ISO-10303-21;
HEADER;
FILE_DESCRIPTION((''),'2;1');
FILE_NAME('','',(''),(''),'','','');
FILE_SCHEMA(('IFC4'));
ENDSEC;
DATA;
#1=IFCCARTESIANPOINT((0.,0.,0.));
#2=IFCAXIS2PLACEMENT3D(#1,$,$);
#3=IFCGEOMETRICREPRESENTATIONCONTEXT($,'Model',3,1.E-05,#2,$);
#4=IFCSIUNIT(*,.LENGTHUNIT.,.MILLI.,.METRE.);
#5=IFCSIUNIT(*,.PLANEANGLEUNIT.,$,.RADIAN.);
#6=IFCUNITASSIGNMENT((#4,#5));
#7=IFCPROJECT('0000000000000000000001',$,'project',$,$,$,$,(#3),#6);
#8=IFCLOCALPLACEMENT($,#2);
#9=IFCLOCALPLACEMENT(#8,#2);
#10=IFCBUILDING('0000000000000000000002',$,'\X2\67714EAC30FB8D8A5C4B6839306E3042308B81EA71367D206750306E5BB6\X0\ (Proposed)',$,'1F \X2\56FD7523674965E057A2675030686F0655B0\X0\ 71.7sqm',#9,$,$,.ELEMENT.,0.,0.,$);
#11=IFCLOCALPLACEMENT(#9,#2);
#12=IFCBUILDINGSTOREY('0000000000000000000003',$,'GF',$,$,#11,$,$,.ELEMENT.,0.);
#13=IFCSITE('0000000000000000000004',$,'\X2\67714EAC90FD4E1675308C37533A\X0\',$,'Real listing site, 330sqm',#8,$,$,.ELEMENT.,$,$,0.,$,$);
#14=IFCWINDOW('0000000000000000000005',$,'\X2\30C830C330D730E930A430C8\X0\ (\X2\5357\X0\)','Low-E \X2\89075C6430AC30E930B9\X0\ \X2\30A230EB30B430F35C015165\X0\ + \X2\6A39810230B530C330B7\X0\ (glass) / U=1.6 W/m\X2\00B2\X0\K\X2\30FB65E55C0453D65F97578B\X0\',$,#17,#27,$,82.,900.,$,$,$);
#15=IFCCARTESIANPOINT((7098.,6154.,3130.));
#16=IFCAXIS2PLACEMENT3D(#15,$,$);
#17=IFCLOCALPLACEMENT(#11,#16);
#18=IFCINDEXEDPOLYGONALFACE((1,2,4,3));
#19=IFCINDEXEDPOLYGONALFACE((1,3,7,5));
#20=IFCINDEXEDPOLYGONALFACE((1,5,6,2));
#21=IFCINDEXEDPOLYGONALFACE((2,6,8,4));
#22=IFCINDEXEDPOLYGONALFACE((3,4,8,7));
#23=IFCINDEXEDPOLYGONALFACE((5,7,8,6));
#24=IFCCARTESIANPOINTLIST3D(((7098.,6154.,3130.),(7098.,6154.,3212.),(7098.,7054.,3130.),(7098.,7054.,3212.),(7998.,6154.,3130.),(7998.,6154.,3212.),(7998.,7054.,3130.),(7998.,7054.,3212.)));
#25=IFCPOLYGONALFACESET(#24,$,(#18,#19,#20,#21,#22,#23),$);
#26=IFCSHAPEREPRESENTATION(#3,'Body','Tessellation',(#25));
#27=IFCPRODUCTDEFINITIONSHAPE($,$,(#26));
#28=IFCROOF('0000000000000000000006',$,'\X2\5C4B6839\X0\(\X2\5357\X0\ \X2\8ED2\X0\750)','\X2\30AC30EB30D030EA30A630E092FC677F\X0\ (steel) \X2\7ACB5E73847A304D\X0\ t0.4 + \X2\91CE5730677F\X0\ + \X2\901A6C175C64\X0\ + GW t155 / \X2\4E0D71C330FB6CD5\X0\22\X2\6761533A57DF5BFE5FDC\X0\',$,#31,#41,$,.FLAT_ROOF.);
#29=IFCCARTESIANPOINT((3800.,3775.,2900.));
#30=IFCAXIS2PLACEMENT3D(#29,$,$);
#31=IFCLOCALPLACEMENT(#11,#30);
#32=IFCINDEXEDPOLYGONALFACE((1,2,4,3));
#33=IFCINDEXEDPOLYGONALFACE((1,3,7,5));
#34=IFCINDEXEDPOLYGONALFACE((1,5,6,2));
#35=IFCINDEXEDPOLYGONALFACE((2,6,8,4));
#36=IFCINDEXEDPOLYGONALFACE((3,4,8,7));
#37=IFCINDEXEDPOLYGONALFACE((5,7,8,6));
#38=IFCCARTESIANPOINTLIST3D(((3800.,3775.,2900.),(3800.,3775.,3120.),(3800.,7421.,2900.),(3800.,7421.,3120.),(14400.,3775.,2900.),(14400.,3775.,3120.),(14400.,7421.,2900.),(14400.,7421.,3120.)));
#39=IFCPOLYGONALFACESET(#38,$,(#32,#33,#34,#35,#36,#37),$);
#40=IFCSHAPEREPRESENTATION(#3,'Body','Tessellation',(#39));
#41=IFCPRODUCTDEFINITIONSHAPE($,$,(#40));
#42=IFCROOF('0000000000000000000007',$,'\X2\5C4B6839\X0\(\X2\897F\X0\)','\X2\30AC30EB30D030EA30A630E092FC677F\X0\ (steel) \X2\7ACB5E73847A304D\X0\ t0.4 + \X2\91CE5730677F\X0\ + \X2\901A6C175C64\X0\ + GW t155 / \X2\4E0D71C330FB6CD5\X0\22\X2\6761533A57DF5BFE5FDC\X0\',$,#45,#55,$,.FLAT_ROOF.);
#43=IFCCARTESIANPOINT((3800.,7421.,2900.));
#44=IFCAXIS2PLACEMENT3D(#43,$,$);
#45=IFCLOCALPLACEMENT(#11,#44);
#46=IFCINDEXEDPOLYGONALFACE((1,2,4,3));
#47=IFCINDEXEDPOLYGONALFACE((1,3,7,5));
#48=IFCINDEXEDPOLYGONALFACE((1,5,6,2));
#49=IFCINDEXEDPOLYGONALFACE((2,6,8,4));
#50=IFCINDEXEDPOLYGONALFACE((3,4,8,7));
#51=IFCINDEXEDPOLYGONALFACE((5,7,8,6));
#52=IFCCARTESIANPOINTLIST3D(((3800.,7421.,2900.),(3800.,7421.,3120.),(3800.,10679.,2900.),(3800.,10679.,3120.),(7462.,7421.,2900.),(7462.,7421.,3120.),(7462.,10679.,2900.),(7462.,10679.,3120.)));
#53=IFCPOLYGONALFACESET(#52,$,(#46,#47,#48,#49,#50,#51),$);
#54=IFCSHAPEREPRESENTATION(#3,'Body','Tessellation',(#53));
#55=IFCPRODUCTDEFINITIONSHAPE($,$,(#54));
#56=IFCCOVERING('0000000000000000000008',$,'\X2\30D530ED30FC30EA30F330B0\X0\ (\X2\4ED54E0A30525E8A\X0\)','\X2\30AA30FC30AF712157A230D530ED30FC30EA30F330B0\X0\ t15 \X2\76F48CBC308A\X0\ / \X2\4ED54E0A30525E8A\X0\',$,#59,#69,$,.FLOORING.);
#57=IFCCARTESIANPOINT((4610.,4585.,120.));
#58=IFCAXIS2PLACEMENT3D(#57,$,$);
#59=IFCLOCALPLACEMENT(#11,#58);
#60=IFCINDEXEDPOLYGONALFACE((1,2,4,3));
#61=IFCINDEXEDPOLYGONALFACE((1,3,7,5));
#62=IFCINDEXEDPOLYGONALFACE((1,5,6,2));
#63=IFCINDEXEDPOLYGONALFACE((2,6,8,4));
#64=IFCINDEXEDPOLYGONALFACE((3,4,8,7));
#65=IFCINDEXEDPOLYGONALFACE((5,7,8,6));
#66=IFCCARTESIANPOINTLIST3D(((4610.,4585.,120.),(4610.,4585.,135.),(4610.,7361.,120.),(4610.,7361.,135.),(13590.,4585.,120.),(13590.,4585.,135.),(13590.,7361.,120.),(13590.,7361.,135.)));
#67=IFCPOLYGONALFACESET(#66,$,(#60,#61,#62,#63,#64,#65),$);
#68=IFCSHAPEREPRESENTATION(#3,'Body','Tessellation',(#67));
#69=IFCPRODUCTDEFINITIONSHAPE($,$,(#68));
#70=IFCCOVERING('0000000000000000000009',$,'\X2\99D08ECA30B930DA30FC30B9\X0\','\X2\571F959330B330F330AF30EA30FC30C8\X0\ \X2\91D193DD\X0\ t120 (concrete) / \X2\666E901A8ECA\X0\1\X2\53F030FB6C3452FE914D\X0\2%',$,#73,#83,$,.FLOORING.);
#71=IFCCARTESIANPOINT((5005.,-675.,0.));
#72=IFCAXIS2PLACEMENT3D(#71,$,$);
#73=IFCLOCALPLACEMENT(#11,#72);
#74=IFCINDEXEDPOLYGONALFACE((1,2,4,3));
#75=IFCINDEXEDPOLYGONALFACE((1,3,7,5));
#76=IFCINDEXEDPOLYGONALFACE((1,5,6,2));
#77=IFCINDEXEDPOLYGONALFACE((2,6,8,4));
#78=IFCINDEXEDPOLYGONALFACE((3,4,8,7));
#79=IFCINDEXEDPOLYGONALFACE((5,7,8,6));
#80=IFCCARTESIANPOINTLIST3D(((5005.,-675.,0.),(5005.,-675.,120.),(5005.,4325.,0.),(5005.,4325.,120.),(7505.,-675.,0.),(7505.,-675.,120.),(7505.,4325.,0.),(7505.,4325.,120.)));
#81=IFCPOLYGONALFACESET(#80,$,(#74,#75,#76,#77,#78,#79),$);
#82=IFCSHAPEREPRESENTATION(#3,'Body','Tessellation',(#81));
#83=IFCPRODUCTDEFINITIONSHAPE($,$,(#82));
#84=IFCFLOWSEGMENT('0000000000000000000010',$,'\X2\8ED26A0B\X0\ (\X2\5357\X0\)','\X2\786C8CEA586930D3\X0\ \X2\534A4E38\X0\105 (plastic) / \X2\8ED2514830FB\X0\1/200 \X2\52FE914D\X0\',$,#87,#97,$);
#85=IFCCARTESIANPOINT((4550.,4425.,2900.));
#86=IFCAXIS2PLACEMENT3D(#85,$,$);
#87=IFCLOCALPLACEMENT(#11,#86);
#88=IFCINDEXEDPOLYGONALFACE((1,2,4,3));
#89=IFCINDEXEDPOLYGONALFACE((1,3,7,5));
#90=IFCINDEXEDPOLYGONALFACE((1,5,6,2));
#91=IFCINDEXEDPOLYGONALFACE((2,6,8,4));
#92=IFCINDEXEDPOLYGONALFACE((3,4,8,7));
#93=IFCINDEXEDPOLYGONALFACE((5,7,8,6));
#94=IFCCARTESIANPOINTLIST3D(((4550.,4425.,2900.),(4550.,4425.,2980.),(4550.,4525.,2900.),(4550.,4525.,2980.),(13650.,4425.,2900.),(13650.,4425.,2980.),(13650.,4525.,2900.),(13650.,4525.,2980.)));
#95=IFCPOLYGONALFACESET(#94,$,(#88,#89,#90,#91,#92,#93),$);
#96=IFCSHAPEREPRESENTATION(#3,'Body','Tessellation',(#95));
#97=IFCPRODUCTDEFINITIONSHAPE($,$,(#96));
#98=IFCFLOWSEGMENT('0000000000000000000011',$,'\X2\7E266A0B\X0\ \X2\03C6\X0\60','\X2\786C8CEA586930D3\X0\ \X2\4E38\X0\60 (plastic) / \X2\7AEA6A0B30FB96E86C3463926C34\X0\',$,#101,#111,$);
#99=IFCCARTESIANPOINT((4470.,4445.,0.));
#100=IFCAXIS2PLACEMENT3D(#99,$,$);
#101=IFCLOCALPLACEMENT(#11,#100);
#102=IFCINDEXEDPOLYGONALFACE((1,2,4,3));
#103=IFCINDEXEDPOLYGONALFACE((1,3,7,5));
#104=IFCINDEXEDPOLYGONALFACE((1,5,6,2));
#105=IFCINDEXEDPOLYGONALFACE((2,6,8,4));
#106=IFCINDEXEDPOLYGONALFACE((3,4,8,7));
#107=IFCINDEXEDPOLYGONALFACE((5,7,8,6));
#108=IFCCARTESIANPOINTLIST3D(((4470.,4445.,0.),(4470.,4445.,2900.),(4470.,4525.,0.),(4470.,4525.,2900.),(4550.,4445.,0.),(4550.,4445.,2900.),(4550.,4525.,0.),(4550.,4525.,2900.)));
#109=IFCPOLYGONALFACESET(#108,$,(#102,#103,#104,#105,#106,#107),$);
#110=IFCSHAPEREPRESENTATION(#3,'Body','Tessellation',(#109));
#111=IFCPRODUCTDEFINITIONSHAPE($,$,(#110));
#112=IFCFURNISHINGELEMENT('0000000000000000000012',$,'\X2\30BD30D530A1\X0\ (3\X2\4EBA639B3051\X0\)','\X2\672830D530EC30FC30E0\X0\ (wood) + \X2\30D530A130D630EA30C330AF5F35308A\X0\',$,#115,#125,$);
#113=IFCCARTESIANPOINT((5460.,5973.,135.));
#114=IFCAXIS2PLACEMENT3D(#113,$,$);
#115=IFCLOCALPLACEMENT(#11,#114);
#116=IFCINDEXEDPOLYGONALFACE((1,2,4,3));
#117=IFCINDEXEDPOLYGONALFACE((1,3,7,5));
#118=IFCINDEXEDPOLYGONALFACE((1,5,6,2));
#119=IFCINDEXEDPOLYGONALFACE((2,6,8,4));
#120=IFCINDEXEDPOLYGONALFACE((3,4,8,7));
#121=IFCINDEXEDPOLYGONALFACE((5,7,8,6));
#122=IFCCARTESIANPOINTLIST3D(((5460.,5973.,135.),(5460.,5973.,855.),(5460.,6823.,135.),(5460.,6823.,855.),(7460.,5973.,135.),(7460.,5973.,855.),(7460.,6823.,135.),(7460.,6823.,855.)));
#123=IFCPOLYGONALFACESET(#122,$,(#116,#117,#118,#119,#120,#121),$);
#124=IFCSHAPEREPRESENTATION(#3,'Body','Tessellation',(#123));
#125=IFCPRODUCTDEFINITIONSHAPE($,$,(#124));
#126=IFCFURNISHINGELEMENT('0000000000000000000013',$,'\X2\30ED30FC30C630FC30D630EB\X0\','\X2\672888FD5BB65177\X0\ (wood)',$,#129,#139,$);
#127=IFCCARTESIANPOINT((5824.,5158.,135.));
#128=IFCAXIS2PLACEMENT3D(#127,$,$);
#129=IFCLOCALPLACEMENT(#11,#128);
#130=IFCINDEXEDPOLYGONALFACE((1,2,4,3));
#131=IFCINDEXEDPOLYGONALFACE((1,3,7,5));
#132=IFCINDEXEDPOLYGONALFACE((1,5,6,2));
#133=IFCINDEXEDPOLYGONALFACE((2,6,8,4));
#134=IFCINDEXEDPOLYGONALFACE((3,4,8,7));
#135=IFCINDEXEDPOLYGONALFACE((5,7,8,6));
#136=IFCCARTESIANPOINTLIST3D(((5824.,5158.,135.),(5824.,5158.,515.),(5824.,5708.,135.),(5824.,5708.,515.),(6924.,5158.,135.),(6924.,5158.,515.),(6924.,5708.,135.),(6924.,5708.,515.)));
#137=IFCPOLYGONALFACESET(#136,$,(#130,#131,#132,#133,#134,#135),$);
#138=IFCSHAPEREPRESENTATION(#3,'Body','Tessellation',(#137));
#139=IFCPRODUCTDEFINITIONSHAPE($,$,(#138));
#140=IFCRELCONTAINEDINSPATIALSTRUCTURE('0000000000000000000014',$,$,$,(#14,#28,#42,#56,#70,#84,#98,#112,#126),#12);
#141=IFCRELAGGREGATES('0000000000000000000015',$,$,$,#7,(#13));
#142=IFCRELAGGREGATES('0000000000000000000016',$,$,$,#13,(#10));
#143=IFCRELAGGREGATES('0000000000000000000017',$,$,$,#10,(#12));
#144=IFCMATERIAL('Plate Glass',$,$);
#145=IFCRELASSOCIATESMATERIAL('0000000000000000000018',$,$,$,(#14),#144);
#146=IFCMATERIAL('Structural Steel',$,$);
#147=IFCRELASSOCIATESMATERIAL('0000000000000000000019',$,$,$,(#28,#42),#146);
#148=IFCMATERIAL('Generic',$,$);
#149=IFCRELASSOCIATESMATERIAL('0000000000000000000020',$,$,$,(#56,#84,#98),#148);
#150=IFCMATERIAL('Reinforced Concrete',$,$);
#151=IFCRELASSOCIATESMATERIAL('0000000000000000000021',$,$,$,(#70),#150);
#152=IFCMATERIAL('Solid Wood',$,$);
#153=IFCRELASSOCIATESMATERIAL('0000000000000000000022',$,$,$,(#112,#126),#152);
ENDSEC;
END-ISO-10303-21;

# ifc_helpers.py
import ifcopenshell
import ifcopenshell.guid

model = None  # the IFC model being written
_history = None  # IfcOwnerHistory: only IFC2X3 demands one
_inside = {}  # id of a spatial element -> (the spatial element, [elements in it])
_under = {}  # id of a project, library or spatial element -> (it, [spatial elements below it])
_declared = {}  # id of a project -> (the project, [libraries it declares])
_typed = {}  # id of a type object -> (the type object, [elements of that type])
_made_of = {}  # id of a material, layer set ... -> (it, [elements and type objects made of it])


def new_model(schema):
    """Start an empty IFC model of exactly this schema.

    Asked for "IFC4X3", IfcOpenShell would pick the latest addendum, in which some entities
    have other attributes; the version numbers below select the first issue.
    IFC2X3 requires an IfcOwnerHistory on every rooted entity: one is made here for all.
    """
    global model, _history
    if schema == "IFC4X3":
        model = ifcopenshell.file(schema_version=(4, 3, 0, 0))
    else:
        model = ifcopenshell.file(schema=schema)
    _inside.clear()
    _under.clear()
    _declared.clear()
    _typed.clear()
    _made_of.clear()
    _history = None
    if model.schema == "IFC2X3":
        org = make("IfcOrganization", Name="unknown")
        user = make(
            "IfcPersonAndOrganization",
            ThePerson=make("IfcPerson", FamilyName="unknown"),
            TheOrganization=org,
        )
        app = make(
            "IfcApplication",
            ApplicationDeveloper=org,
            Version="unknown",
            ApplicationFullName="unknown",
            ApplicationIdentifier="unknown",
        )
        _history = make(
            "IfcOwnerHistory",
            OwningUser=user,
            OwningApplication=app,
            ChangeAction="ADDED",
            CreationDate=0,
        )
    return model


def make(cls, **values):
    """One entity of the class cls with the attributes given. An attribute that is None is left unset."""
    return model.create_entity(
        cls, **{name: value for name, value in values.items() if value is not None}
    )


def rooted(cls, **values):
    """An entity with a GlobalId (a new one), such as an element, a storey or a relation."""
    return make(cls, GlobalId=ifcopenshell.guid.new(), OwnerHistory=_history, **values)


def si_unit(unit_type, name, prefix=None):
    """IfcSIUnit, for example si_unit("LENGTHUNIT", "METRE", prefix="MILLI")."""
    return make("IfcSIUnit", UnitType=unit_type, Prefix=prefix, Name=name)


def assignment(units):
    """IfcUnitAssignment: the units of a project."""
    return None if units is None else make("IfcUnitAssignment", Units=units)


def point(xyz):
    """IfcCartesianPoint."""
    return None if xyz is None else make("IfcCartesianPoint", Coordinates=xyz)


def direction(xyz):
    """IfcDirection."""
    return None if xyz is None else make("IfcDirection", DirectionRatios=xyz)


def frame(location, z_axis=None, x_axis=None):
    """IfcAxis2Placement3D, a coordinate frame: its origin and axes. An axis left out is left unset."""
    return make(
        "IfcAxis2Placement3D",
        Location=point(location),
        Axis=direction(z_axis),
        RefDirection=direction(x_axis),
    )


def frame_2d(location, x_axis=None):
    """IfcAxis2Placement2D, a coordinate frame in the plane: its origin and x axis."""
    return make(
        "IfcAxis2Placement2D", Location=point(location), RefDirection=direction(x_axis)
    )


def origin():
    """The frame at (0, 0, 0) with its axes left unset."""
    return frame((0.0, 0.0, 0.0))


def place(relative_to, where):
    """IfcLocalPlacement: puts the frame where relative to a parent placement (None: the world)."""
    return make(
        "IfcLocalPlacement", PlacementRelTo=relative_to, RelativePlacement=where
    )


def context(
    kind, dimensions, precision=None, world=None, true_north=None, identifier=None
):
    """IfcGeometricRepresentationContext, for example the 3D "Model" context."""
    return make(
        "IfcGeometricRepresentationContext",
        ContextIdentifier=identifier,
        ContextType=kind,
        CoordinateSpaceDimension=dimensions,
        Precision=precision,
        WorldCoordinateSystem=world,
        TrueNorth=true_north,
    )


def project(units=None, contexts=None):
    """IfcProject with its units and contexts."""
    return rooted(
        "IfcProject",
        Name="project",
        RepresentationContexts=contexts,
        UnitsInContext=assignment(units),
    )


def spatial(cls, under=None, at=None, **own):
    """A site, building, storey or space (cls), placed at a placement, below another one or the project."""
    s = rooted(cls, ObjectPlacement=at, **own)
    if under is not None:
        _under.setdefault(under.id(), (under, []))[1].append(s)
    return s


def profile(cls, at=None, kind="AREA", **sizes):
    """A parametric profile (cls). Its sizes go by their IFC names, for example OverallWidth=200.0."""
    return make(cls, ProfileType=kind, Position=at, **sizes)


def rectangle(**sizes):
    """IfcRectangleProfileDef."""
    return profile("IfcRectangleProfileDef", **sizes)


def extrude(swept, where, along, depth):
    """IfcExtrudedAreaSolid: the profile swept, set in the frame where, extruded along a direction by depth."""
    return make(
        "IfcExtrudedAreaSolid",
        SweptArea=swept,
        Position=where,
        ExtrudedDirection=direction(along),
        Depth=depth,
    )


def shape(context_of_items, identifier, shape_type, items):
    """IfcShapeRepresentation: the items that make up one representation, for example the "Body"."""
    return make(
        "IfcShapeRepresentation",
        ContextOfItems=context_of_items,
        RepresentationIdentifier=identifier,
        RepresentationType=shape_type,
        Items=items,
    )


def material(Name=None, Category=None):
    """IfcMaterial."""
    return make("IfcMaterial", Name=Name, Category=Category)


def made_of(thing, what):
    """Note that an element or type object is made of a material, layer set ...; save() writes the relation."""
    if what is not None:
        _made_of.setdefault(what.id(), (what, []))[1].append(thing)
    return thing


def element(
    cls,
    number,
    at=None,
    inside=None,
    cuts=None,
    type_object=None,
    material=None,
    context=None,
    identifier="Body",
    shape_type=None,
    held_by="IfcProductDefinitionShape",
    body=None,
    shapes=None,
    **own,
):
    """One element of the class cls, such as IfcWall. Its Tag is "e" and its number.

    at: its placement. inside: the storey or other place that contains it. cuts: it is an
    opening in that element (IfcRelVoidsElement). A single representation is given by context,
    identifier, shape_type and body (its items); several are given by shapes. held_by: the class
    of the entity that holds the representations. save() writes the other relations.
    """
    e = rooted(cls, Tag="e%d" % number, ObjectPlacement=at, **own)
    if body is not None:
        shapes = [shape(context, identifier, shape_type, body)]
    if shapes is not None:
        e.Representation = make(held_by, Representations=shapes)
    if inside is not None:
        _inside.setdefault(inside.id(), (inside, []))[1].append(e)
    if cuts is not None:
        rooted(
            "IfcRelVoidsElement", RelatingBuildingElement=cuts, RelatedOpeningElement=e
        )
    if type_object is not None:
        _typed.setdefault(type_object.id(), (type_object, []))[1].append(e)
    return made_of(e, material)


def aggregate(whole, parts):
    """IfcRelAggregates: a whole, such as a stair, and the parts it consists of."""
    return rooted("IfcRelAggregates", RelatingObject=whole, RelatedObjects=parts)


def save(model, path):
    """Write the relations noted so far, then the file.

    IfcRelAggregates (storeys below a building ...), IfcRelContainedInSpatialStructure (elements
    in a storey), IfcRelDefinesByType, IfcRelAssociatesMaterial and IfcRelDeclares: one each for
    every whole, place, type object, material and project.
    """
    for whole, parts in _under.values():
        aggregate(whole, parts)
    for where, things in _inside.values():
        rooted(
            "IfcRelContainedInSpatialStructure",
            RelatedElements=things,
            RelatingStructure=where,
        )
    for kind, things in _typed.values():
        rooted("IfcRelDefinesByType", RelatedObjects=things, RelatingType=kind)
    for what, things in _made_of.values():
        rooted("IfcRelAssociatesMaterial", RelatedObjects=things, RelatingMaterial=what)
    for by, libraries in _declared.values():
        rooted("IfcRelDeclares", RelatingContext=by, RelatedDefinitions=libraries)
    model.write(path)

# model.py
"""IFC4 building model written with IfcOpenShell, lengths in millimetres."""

from ifc_helpers import new_model, si_unit, frame, frame_2d, origin, place, context, project, spatial, rectangle, extrude, material, element, save


model = new_model("IFC4")

# Units and contexts
model_context = context("Model", 3, precision=1e-05, world=origin())
ifc_project = project(units=[si_unit("LENGTHUNIT", "METRE", prefix="MILLI"), si_unit("PLANEANGLEUNIT", "RADIAN")], contexts=[model_context])

# Site, building, storey
site_placement = place(None, origin())
site = spatial("IfcSite", under=ifc_project, at=site_placement, Name="東京都世田谷区", ObjectType="Real listing site, 330sqm", CompositionType="ELEMENT", RefElevation=0.0)
building_placement = place(site_placement, origin())
building = spatial("IfcBuilding", under=site, at=building_placement, Name="東京・越屋根のある自然素材の家 (Proposed)", ObjectType="1F 国産杉无垢材と漆喰 71.7sqm", CompositionType="ELEMENT", ElevationOfRefHeight=0.0, ElevationOfTerrain=0.0)
storey_placement = place(building_placement, origin())
storey = spatial("IfcBuildingStorey", under=building, at=storey_placement, Name="GF", CompositionType="ELEMENT", Elevation=0.0)

# Shared definitions
ifc_material_1 = material(Name="Solid Wood")

# Shared definitions
ifc_material_2 = material(Name="Reinforced Concrete")

# Shared definitions
ifc_material_3 = material(Name="Plate Glass")

# Window
window_1_placement = place(storey_placement, frame((7098.0, 6154.0, 3130.0)))
element("IfcWindow", 1, at=window_1_placement, inside=storey, material=ifc_material_3, Name="トップライト (南)", Description="Low-E 複層ガラス アルゴン封入 + 樹脂サッシ (glass) / U=1.6 W/m²K・日射取得型", OverallHeight=82.0, OverallWidth=900.0, context=model_context, shape_type="SweptSolid", body=[
    extrude(rectangle(XDim=900.0, YDim=900.0, at=frame_2d((450.0, 450.0))), frame((7098.0, 6154.0, 3130.0)), (0.0, 0.0, 1.0), 82.0),
])

# Roofs
ifc_material_4 = material(Name="Structural Steel")
roof_1_placement = place(storey_placement, frame((3800.0, 3775.0, 2900.0)))
element("IfcRoof", 2, at=roof_1_placement, inside=storey, material=ifc_material_4, Name="屋根(南 軒750)", Description="ガルバリウム鋼板 (steel) 立平葺き t0.4 + 野地板 + 通気層 + GW t155 / 不燃・法22条区域対応", PredefinedType="FLAT_ROOF", context=model_context, shape_type="SweptSolid", body=[
    extrude(rectangle(XDim=10600.0, YDim=3646.0, at=frame_2d((5300.0, 1823.0))), frame((3800.0, 3775.0, 2900.0)), (0.0, 0.0, 1.0), 220.0),
])
roof_2_placement = place(storey_placement, frame((3800.0, 7421.0, 2900.0)))
element("IfcRoof", 3, at=roof_2_placement, inside=storey, material=ifc_material_4, Name="屋根(西)", Description="ガルバリウム鋼板 (steel) 立平葺き t0.4 + 野地板 + 通気層 + GW t155 / 不燃・法22条区域対応", PredefinedType="FLAT_ROOF", context=model_context, shape_type="SweptSolid", body=[
    extrude(rectangle(XDim=3662.0, YDim=3258.0, at=frame_2d((1831.0, 1629.0))), frame((3800.0, 7421.0, 2900.0)), (0.0, 0.0, 1.0), 220.0),
])

# Coverings
ifc_material_5 = material(Name="Generic")
covering_1_placement = place(storey_placement, frame((4610.0, 4585.0, 120.0)))
element("IfcCovering", 4, at=covering_1_placement, inside=storey, material=ifc_material_5, Name="フローリング (仕上げ床)", Description="オーク無垢フローリング t15 直貼り / 仕上げ床", PredefinedType="FLOORING", context=model_context, shape_type="SweptSolid", body=[
    extrude(rectangle(XDim=8980.0, YDim=2776.0, at=frame_2d((4490.0, 1388.0))), frame((4610.0, 4585.0, 120.0)), (0.0, 0.0, 1.0), 15.0),
])
covering_2_placement = place(storey_placement, frame((5005.0, -675.0, 0.0)))
element("IfcCovering", 5, at=covering_2_placement, inside=storey, material=ifc_material_2, Name="駐車スペース", Description="土間コンクリート 金鏝 t120 (concrete) / 普通車1台・水勾配2%", PredefinedType="FLOORING", context=model_context, shape_type="SweptSolid", body=[
    extrude(rectangle(XDim=2500.0, YDim=5000.0, at=frame_2d((1250.0, 2500.0))), frame((5005.0, -675.0, 0.0)), (0.0, 0.0, 1.0), 120.0),
])

# Flow segments
flow_segment_1_placement = place(storey_placement, frame((4550.0, 4425.0, 2900.0)))
element("IfcFlowSegment", 6, at=flow_segment_1_placement, inside=storey, material=ifc_material_5, Name="軒樋 (南)", Description="硬質塩ビ 半丸105 (plastic) / 軒先・1/200 勾配", context=model_context, shape_type="SweptSolid", body=[
    extrude(rectangle(XDim=9100.0, YDim=100.0, at=frame_2d((4550.0, 50.0))), frame((4550.0, 4425.0, 2900.0)), (0.0, 0.0, 1.0), 80.0),
])
flow_segment_2_placement = place(storey_placement, frame((4470.0, 4445.0, 0.0)))
element("IfcFlowSegment", 7, at=flow_segment_2_placement, inside=storey, material=ifc_material_5, Name="縦樋 φ60", Description="硬質塩ビ 丸60 (plastic) / 竪樋・雨水排水", context=model_context, shape_type="SweptSolid", body=[
    extrude(rectangle(XDim=80.0, YDim=80.0, at=frame_2d((40.0, 40.0))), frame((4470.0, 4445.0, 0.0)), (0.0, 0.0, 1.0), 2900.0),
])

# Furnishing elements
furnishing_1_placement = place(storey_placement, frame((5460.0, 5973.0, 135.0)))
element("IfcFurnishingElement", 8, at=furnishing_1_placement, inside=storey, material=ifc_material_1, Name="ソファ (3人掛け)", Description="木フレーム (wood) + ファブリック張り", context=model_context, shape_type="SweptSolid", body=[
    extrude(rectangle(XDim=2000.0, YDim=850.0, at=frame_2d((1000.0, 425.0))), frame((5460.0, 5973.0, 135.0)), (0.0, 0.0, 1.0), 720.0),
])
furnishing_2_placement = place(storey_placement, frame((5824.0, 5158.0, 135.0)))
element("IfcFurnishingElement", 9, at=furnishing_2_placement, inside=storey, material=ifc_material_1, Name="ローテーブル", Description="木製家具 (wood)", context=model_context, shape_type="SweptSolid", body=[
    extrude(rectangle(XDim=1100.0, YDim=550.0, at=frame_2d((550.0, 275.0))), frame((5824.0, 5158.0, 135.0)), (0.0, 0.0, 1.0), 380.0),
])

save(model, "model.ifc")
